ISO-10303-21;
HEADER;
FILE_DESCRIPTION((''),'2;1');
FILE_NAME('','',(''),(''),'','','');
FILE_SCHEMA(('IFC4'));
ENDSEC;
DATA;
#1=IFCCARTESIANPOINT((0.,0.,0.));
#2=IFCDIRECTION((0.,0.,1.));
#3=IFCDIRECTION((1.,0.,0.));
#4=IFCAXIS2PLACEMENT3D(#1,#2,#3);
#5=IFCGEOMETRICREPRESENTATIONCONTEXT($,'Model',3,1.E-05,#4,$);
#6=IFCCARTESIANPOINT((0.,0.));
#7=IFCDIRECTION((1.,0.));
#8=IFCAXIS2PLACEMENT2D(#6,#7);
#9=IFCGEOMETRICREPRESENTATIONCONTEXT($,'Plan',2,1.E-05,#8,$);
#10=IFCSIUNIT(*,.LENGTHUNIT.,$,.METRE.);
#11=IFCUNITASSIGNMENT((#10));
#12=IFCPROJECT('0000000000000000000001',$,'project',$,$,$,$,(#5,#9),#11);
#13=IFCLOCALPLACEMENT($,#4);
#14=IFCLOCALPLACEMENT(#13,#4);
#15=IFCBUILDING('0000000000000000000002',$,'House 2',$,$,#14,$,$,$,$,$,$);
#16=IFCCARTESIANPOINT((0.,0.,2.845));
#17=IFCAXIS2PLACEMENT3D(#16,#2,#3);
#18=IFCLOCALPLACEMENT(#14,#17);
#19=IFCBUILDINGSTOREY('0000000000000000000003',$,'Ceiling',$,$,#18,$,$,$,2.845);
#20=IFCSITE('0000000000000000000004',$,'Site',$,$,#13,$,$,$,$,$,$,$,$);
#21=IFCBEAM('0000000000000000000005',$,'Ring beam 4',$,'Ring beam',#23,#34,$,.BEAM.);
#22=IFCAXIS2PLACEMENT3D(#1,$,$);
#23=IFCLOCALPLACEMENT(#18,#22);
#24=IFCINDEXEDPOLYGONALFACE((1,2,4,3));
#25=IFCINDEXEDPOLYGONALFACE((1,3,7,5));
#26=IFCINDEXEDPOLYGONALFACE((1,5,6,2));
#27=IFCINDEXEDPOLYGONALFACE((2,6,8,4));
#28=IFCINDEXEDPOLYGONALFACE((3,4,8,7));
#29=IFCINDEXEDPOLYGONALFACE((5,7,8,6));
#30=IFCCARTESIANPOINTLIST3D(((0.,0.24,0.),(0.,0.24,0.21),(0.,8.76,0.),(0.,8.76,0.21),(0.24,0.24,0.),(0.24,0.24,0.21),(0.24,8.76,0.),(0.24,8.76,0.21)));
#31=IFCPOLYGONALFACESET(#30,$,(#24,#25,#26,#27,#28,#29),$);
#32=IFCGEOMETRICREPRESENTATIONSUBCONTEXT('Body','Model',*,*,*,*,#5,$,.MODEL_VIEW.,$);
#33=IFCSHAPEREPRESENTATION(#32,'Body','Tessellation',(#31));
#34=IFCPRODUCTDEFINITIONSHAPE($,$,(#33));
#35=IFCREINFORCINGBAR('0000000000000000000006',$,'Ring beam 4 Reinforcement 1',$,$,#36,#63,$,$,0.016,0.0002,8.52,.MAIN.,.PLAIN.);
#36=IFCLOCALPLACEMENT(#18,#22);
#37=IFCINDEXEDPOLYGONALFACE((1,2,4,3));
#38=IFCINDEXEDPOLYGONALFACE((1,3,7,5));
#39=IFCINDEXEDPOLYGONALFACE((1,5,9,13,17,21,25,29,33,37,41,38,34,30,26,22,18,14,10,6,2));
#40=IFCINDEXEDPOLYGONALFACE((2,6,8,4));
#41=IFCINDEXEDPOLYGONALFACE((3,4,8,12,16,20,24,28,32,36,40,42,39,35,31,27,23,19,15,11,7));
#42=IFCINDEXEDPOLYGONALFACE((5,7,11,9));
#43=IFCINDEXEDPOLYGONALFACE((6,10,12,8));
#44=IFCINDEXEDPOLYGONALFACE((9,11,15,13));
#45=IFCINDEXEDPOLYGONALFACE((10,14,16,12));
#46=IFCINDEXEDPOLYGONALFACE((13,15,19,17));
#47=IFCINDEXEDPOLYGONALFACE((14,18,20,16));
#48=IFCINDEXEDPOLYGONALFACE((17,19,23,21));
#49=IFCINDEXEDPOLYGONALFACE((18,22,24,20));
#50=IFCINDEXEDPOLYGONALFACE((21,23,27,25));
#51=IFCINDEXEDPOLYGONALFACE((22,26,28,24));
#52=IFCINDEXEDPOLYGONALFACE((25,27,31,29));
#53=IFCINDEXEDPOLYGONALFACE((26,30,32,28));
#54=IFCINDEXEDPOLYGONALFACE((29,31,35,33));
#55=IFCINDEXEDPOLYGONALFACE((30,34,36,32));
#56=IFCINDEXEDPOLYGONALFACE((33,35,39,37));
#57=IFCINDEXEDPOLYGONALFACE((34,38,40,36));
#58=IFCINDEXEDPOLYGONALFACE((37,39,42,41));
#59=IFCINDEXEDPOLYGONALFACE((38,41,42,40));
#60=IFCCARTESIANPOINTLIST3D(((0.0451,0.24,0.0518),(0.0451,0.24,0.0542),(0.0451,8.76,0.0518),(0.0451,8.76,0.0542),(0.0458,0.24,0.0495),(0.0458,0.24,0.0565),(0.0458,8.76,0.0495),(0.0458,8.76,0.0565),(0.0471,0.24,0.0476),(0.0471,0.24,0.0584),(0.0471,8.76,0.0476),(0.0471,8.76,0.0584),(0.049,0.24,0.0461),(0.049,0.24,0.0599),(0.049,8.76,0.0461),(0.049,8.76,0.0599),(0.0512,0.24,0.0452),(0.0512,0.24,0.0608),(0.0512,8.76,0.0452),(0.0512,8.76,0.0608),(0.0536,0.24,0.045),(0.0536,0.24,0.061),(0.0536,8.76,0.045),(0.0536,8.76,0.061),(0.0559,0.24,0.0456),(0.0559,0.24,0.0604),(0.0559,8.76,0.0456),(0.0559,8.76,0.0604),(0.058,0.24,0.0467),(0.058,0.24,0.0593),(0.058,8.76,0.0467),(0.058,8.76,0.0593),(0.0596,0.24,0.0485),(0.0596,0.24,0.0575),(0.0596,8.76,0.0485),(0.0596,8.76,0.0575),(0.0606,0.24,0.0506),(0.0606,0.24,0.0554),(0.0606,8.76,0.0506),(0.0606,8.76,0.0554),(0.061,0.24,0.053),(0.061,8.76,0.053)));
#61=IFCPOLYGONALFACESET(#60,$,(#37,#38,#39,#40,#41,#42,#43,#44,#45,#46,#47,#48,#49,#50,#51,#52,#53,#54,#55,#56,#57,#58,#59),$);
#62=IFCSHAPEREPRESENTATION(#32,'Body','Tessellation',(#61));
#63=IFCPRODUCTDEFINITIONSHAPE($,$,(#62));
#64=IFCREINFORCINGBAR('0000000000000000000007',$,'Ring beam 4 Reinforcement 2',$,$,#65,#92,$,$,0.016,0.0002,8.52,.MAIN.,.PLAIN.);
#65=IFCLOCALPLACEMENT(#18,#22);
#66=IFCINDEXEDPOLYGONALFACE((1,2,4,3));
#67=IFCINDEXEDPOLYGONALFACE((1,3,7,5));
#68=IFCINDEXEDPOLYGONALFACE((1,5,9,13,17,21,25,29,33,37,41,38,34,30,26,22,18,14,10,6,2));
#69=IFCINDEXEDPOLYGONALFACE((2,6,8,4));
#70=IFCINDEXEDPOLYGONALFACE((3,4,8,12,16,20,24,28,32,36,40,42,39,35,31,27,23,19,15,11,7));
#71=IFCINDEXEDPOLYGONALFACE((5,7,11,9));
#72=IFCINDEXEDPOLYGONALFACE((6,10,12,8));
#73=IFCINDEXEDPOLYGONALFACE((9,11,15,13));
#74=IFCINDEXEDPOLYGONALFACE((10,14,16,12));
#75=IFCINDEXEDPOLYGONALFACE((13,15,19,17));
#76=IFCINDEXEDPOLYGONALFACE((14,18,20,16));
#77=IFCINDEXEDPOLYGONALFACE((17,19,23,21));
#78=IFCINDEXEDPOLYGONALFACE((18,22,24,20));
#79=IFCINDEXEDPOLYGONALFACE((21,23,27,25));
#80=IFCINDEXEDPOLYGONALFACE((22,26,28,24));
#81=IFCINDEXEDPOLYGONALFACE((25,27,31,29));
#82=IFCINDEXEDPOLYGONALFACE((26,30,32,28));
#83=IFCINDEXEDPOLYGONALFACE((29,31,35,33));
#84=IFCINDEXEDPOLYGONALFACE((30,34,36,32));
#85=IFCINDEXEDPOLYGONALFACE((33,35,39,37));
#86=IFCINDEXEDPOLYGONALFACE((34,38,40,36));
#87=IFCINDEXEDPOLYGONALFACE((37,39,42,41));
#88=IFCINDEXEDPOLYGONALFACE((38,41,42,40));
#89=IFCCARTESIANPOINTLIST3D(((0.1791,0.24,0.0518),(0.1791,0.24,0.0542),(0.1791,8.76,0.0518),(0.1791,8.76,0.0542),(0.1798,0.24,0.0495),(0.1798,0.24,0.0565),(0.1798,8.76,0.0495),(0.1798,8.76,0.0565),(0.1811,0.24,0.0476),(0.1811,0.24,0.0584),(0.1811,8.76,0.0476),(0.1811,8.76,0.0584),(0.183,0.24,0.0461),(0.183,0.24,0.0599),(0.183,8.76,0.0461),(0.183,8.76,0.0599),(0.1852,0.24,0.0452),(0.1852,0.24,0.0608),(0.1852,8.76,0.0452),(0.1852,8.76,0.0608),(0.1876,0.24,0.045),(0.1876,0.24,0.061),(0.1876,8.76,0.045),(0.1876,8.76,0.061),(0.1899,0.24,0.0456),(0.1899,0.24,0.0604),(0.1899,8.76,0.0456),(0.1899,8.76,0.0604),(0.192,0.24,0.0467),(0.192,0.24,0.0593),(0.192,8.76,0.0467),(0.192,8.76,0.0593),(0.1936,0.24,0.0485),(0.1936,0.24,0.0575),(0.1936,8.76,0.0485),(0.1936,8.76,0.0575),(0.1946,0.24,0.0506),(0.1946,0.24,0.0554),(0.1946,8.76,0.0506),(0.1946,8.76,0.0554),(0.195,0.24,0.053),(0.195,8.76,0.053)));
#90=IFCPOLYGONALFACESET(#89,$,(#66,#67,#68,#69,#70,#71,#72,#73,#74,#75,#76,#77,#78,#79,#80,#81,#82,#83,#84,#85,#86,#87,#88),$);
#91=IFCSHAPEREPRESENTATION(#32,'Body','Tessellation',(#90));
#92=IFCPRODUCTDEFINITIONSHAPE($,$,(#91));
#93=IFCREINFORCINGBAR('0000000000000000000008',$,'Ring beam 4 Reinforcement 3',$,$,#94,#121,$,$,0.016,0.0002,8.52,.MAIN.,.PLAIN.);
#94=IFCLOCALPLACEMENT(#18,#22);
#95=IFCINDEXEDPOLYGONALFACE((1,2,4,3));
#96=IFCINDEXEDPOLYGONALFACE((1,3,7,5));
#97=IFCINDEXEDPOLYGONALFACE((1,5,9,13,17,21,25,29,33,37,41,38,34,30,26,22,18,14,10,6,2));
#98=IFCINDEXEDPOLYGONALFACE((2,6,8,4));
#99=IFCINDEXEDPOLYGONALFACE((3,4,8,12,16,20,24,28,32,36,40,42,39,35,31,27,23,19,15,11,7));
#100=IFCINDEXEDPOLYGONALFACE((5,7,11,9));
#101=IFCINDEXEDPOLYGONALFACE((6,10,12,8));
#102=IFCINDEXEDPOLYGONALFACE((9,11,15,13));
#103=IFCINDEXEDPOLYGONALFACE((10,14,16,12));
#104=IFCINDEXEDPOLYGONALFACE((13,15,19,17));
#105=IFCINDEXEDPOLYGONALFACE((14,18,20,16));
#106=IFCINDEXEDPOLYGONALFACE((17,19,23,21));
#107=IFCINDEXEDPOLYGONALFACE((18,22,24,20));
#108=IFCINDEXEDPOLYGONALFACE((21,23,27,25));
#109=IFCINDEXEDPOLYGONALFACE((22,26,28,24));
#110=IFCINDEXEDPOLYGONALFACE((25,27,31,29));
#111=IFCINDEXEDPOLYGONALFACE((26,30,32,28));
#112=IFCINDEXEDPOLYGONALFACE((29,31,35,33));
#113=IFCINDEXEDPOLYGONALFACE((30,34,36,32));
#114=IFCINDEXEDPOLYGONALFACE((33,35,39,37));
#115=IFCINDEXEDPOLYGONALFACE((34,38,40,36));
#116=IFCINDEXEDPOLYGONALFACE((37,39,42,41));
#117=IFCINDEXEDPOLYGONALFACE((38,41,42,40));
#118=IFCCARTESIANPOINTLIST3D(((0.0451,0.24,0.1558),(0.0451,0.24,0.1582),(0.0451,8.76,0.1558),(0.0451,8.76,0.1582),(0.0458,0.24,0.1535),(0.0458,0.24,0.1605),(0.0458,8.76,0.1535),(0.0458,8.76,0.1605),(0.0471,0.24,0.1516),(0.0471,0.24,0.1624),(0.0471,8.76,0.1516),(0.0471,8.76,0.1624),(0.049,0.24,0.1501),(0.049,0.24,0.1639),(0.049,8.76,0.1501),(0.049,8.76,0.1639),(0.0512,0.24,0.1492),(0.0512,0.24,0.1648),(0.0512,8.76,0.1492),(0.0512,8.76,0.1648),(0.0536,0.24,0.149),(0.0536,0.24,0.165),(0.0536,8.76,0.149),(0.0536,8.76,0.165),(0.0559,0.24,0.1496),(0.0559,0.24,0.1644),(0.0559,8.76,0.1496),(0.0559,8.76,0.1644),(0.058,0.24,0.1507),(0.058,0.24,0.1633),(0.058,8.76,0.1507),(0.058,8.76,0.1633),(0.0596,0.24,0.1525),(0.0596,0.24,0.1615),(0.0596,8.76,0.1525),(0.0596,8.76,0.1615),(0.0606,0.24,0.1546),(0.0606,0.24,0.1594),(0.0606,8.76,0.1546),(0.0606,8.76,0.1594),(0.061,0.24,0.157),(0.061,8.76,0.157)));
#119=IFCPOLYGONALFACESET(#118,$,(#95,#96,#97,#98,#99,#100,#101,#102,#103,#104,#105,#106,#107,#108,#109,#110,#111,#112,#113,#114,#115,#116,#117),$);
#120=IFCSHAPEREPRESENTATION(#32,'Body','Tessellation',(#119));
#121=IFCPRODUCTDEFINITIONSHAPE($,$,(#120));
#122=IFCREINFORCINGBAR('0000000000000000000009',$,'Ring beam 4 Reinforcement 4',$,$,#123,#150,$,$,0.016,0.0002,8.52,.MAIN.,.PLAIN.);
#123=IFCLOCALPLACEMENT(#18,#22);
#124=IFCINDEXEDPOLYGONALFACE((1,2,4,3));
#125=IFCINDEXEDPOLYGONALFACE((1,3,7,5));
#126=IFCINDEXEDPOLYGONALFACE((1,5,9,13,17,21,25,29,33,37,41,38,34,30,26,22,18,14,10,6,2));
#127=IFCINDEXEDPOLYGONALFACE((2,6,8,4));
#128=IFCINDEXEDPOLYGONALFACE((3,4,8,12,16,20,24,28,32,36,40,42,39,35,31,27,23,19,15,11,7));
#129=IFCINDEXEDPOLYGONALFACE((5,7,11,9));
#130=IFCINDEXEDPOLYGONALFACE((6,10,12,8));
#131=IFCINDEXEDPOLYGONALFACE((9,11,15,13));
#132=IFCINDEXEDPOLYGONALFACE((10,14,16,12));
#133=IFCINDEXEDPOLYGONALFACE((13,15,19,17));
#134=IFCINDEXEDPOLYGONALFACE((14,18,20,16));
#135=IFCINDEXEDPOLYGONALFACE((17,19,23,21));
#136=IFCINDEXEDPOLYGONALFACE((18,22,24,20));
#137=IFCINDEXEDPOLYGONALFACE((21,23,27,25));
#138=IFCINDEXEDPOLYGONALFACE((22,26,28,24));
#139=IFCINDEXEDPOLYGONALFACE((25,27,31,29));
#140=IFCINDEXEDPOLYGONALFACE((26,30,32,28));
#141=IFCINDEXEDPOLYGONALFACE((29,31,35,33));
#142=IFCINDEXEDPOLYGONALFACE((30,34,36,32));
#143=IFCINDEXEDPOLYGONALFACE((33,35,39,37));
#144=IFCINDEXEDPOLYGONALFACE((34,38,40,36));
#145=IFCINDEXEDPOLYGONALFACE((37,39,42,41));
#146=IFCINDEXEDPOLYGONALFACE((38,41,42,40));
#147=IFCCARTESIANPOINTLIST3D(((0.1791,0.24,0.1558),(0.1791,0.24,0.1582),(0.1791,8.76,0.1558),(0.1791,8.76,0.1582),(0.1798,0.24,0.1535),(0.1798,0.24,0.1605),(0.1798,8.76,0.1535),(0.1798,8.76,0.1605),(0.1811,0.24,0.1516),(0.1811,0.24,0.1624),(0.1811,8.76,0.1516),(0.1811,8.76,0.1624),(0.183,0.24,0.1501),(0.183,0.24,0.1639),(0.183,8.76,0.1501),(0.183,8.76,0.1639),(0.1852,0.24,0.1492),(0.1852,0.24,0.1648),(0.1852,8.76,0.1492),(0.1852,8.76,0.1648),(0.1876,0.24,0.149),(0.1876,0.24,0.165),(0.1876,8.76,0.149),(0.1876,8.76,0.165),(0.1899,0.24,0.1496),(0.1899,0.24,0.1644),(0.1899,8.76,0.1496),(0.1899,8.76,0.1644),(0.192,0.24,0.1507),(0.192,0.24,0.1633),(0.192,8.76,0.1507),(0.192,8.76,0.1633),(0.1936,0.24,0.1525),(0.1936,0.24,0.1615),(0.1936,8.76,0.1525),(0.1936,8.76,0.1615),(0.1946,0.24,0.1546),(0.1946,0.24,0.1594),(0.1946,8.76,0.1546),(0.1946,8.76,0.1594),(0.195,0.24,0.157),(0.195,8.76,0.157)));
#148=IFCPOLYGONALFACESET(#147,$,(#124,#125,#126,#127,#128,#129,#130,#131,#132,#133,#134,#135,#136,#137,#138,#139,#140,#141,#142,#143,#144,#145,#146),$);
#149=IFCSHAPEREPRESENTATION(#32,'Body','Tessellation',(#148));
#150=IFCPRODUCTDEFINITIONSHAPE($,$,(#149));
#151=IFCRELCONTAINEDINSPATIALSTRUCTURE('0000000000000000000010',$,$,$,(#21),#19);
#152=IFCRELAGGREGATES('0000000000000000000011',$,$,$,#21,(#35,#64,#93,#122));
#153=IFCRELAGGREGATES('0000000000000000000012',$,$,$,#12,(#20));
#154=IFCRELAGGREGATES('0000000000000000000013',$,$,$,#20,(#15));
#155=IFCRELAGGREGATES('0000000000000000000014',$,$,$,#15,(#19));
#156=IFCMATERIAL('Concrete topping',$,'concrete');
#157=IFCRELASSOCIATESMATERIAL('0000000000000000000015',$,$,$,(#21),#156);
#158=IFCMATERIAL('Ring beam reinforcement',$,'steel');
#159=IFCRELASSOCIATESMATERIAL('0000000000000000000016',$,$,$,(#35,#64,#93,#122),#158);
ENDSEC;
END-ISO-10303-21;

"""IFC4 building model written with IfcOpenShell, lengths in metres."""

from ifc_helpers import new_model, si_unit, frame, origin_with_axes, origin_2d, origin_2d_with_axis, place, context, subcontext, project, spatial, circle_curve, rectangle, outline, extrude, material, element, aggregate, save


model = new_model("IFC4")

# Units and contexts
model_context = context("Model", 3, precision=1e-05, world=origin_with_axes())
plan_context = context("Plan", 2, precision=1e-05, world=origin_2d_with_axis())
body_context_1 = subcontext(model_context, "Body", "Model", "MODEL_VIEW")
ifc_project = project(units=[si_unit("LENGTHUNIT", "METRE")], contexts=[model_context, plan_context])

# Site, building, storey
site_placement = place(None, origin_with_axes())
building_placement = place(site_placement, origin_with_axes())
storey_placement = place(building_placement, frame((0.0, 0.0, 2.845), z_axis=(0.0, 0.0, 1.0), x_axis=(1.0, 0.0, 0.0)))
site = spatial("IfcSite", under=ifc_project, at=site_placement, Name="Site")
building = spatial("IfcBuilding", under=site, at=building_placement, Name="House 2")
storey = spatial("IfcBuildingStorey", under=building, at=storey_placement, Name="Ceiling", Elevation=2.845)

# Beam
ifc_material_1 = material(Name="Concrete topping", Category="concrete")
beam_1_placement = place(storey_placement, frame((0.12, 8.76, 0.105), z_axis=(0.0, 0.0, 1.0), x_axis=(0.0, -1.0, 0.0)))
beam_1 = element("IfcBeam", 1, at=beam_1_placement, inside=storey, material=ifc_material_1, Name="Ring beam 4", ObjectType="Ring beam", PredefinedType="BEAM", context=body_context_1, shape_type="SweptSolid", body=[
    extrude(rectangle(XDim=0.24, YDim=0.21), frame((0.0, 0.0, 0.0), z_axis=(1.0, 0.0, 0.0), x_axis=(0.0, 1.0, 0.0)), (0.0, 0.0, 1.0), 8.52),
])

# Reinforcing bars
ifc_material_2 = material(Name="Ring beam reinforcement", Category="steel")
reinforcing_bar_1_placement = place(beam_1_placement, frame((0.0, -0.067, -0.052), z_axis=(0.0, 0.0, 1.0), x_axis=(1.0, 0.0, 0.0)))
reinforcing_bar_1 = element("IfcReinforcingBar", 2, at=reinforcing_bar_1_placement, material=ifc_material_2, Name="Ring beam 4 Reinforcement 1", BarLength=8.52, BarSurface="PLAIN", CrossSectionArea=0.0002, NominalDiameter=0.016, PredefinedType="MAIN", context=body_context_1, shape_type="SweptSolid", body=[
    extrude(outline(circle_curve(origin_2d(), 0.008)), frame((0.0, 0.0, 0.0), z_axis=(1.0, 0.0, 0.0), x_axis=(0.0, 1.0, 0.0)), (0.0, 0.0, 1.0), 8.52),
])
reinforcing_bar_2_placement = place(beam_1_placement, frame((0.0, 0.067, -0.052), z_axis=(0.0, 0.0, 1.0), x_axis=(1.0, 0.0, 0.0)))
reinforcing_bar_2 = element("IfcReinforcingBar", 3, at=reinforcing_bar_2_placement, material=ifc_material_2, Name="Ring beam 4 Reinforcement 2", BarLength=8.52, BarSurface="PLAIN", CrossSectionArea=0.0002, NominalDiameter=0.016, PredefinedType="MAIN", context=body_context_1, shape_type="SweptSolid", body=[
    extrude(outline(circle_curve(origin_2d(), 0.008)), frame((0.0, 0.0, 0.0), z_axis=(1.0, 0.0, 0.0), x_axis=(0.0, 1.0, 0.0)), (0.0, 0.0, 1.0), 8.52),
])
reinforcing_bar_3_placement = place(beam_1_placement, frame((0.0, -0.067, 0.052), z_axis=(0.0, 0.0, 1.0), x_axis=(1.0, 0.0, 0.0)))
reinforcing_bar_3 = element("IfcReinforcingBar", 4, at=reinforcing_bar_3_placement, material=ifc_material_2, Name="Ring beam 4 Reinforcement 3", BarLength=8.52, BarSurface="PLAIN", CrossSectionArea=0.0002, NominalDiameter=0.016, PredefinedType="MAIN", context=body_context_1, shape_type="SweptSolid", body=[
    extrude(outline(circle_curve(origin_2d(), 0.008)), frame((0.0, 0.0, 0.0), z_axis=(1.0, 0.0, 0.0), x_axis=(0.0, 1.0, 0.0)), (0.0, 0.0, 1.0), 8.52),
])
reinforcing_bar_4_placement = place(beam_1_placement, frame((0.0, 0.067, 0.052), z_axis=(0.0, 0.0, 1.0), x_axis=(1.0, 0.0, 0.0)))
reinforcing_bar_4 = element("IfcReinforcingBar", 5, at=reinforcing_bar_4_placement, material=ifc_material_2, Name="Ring beam 4 Reinforcement 4", BarLength=8.52, BarSurface="PLAIN", CrossSectionArea=0.0002, NominalDiameter=0.016, PredefinedType="MAIN", context=body_context_1, shape_type="SweptSolid", body=[
    extrude(outline(circle_curve(origin_2d(), 0.008)), frame((0.0, 0.0, 0.0), z_axis=(1.0, 0.0, 0.0), x_axis=(0.0, 1.0, 0.0)), (0.0, 0.0, 1.0), 8.52),
])
aggregate(beam_1, [reinforcing_bar_1, reinforcing_bar_2, reinforcing_bar_3, reinforcing_bar_4])

save(model, "model.ifc")
